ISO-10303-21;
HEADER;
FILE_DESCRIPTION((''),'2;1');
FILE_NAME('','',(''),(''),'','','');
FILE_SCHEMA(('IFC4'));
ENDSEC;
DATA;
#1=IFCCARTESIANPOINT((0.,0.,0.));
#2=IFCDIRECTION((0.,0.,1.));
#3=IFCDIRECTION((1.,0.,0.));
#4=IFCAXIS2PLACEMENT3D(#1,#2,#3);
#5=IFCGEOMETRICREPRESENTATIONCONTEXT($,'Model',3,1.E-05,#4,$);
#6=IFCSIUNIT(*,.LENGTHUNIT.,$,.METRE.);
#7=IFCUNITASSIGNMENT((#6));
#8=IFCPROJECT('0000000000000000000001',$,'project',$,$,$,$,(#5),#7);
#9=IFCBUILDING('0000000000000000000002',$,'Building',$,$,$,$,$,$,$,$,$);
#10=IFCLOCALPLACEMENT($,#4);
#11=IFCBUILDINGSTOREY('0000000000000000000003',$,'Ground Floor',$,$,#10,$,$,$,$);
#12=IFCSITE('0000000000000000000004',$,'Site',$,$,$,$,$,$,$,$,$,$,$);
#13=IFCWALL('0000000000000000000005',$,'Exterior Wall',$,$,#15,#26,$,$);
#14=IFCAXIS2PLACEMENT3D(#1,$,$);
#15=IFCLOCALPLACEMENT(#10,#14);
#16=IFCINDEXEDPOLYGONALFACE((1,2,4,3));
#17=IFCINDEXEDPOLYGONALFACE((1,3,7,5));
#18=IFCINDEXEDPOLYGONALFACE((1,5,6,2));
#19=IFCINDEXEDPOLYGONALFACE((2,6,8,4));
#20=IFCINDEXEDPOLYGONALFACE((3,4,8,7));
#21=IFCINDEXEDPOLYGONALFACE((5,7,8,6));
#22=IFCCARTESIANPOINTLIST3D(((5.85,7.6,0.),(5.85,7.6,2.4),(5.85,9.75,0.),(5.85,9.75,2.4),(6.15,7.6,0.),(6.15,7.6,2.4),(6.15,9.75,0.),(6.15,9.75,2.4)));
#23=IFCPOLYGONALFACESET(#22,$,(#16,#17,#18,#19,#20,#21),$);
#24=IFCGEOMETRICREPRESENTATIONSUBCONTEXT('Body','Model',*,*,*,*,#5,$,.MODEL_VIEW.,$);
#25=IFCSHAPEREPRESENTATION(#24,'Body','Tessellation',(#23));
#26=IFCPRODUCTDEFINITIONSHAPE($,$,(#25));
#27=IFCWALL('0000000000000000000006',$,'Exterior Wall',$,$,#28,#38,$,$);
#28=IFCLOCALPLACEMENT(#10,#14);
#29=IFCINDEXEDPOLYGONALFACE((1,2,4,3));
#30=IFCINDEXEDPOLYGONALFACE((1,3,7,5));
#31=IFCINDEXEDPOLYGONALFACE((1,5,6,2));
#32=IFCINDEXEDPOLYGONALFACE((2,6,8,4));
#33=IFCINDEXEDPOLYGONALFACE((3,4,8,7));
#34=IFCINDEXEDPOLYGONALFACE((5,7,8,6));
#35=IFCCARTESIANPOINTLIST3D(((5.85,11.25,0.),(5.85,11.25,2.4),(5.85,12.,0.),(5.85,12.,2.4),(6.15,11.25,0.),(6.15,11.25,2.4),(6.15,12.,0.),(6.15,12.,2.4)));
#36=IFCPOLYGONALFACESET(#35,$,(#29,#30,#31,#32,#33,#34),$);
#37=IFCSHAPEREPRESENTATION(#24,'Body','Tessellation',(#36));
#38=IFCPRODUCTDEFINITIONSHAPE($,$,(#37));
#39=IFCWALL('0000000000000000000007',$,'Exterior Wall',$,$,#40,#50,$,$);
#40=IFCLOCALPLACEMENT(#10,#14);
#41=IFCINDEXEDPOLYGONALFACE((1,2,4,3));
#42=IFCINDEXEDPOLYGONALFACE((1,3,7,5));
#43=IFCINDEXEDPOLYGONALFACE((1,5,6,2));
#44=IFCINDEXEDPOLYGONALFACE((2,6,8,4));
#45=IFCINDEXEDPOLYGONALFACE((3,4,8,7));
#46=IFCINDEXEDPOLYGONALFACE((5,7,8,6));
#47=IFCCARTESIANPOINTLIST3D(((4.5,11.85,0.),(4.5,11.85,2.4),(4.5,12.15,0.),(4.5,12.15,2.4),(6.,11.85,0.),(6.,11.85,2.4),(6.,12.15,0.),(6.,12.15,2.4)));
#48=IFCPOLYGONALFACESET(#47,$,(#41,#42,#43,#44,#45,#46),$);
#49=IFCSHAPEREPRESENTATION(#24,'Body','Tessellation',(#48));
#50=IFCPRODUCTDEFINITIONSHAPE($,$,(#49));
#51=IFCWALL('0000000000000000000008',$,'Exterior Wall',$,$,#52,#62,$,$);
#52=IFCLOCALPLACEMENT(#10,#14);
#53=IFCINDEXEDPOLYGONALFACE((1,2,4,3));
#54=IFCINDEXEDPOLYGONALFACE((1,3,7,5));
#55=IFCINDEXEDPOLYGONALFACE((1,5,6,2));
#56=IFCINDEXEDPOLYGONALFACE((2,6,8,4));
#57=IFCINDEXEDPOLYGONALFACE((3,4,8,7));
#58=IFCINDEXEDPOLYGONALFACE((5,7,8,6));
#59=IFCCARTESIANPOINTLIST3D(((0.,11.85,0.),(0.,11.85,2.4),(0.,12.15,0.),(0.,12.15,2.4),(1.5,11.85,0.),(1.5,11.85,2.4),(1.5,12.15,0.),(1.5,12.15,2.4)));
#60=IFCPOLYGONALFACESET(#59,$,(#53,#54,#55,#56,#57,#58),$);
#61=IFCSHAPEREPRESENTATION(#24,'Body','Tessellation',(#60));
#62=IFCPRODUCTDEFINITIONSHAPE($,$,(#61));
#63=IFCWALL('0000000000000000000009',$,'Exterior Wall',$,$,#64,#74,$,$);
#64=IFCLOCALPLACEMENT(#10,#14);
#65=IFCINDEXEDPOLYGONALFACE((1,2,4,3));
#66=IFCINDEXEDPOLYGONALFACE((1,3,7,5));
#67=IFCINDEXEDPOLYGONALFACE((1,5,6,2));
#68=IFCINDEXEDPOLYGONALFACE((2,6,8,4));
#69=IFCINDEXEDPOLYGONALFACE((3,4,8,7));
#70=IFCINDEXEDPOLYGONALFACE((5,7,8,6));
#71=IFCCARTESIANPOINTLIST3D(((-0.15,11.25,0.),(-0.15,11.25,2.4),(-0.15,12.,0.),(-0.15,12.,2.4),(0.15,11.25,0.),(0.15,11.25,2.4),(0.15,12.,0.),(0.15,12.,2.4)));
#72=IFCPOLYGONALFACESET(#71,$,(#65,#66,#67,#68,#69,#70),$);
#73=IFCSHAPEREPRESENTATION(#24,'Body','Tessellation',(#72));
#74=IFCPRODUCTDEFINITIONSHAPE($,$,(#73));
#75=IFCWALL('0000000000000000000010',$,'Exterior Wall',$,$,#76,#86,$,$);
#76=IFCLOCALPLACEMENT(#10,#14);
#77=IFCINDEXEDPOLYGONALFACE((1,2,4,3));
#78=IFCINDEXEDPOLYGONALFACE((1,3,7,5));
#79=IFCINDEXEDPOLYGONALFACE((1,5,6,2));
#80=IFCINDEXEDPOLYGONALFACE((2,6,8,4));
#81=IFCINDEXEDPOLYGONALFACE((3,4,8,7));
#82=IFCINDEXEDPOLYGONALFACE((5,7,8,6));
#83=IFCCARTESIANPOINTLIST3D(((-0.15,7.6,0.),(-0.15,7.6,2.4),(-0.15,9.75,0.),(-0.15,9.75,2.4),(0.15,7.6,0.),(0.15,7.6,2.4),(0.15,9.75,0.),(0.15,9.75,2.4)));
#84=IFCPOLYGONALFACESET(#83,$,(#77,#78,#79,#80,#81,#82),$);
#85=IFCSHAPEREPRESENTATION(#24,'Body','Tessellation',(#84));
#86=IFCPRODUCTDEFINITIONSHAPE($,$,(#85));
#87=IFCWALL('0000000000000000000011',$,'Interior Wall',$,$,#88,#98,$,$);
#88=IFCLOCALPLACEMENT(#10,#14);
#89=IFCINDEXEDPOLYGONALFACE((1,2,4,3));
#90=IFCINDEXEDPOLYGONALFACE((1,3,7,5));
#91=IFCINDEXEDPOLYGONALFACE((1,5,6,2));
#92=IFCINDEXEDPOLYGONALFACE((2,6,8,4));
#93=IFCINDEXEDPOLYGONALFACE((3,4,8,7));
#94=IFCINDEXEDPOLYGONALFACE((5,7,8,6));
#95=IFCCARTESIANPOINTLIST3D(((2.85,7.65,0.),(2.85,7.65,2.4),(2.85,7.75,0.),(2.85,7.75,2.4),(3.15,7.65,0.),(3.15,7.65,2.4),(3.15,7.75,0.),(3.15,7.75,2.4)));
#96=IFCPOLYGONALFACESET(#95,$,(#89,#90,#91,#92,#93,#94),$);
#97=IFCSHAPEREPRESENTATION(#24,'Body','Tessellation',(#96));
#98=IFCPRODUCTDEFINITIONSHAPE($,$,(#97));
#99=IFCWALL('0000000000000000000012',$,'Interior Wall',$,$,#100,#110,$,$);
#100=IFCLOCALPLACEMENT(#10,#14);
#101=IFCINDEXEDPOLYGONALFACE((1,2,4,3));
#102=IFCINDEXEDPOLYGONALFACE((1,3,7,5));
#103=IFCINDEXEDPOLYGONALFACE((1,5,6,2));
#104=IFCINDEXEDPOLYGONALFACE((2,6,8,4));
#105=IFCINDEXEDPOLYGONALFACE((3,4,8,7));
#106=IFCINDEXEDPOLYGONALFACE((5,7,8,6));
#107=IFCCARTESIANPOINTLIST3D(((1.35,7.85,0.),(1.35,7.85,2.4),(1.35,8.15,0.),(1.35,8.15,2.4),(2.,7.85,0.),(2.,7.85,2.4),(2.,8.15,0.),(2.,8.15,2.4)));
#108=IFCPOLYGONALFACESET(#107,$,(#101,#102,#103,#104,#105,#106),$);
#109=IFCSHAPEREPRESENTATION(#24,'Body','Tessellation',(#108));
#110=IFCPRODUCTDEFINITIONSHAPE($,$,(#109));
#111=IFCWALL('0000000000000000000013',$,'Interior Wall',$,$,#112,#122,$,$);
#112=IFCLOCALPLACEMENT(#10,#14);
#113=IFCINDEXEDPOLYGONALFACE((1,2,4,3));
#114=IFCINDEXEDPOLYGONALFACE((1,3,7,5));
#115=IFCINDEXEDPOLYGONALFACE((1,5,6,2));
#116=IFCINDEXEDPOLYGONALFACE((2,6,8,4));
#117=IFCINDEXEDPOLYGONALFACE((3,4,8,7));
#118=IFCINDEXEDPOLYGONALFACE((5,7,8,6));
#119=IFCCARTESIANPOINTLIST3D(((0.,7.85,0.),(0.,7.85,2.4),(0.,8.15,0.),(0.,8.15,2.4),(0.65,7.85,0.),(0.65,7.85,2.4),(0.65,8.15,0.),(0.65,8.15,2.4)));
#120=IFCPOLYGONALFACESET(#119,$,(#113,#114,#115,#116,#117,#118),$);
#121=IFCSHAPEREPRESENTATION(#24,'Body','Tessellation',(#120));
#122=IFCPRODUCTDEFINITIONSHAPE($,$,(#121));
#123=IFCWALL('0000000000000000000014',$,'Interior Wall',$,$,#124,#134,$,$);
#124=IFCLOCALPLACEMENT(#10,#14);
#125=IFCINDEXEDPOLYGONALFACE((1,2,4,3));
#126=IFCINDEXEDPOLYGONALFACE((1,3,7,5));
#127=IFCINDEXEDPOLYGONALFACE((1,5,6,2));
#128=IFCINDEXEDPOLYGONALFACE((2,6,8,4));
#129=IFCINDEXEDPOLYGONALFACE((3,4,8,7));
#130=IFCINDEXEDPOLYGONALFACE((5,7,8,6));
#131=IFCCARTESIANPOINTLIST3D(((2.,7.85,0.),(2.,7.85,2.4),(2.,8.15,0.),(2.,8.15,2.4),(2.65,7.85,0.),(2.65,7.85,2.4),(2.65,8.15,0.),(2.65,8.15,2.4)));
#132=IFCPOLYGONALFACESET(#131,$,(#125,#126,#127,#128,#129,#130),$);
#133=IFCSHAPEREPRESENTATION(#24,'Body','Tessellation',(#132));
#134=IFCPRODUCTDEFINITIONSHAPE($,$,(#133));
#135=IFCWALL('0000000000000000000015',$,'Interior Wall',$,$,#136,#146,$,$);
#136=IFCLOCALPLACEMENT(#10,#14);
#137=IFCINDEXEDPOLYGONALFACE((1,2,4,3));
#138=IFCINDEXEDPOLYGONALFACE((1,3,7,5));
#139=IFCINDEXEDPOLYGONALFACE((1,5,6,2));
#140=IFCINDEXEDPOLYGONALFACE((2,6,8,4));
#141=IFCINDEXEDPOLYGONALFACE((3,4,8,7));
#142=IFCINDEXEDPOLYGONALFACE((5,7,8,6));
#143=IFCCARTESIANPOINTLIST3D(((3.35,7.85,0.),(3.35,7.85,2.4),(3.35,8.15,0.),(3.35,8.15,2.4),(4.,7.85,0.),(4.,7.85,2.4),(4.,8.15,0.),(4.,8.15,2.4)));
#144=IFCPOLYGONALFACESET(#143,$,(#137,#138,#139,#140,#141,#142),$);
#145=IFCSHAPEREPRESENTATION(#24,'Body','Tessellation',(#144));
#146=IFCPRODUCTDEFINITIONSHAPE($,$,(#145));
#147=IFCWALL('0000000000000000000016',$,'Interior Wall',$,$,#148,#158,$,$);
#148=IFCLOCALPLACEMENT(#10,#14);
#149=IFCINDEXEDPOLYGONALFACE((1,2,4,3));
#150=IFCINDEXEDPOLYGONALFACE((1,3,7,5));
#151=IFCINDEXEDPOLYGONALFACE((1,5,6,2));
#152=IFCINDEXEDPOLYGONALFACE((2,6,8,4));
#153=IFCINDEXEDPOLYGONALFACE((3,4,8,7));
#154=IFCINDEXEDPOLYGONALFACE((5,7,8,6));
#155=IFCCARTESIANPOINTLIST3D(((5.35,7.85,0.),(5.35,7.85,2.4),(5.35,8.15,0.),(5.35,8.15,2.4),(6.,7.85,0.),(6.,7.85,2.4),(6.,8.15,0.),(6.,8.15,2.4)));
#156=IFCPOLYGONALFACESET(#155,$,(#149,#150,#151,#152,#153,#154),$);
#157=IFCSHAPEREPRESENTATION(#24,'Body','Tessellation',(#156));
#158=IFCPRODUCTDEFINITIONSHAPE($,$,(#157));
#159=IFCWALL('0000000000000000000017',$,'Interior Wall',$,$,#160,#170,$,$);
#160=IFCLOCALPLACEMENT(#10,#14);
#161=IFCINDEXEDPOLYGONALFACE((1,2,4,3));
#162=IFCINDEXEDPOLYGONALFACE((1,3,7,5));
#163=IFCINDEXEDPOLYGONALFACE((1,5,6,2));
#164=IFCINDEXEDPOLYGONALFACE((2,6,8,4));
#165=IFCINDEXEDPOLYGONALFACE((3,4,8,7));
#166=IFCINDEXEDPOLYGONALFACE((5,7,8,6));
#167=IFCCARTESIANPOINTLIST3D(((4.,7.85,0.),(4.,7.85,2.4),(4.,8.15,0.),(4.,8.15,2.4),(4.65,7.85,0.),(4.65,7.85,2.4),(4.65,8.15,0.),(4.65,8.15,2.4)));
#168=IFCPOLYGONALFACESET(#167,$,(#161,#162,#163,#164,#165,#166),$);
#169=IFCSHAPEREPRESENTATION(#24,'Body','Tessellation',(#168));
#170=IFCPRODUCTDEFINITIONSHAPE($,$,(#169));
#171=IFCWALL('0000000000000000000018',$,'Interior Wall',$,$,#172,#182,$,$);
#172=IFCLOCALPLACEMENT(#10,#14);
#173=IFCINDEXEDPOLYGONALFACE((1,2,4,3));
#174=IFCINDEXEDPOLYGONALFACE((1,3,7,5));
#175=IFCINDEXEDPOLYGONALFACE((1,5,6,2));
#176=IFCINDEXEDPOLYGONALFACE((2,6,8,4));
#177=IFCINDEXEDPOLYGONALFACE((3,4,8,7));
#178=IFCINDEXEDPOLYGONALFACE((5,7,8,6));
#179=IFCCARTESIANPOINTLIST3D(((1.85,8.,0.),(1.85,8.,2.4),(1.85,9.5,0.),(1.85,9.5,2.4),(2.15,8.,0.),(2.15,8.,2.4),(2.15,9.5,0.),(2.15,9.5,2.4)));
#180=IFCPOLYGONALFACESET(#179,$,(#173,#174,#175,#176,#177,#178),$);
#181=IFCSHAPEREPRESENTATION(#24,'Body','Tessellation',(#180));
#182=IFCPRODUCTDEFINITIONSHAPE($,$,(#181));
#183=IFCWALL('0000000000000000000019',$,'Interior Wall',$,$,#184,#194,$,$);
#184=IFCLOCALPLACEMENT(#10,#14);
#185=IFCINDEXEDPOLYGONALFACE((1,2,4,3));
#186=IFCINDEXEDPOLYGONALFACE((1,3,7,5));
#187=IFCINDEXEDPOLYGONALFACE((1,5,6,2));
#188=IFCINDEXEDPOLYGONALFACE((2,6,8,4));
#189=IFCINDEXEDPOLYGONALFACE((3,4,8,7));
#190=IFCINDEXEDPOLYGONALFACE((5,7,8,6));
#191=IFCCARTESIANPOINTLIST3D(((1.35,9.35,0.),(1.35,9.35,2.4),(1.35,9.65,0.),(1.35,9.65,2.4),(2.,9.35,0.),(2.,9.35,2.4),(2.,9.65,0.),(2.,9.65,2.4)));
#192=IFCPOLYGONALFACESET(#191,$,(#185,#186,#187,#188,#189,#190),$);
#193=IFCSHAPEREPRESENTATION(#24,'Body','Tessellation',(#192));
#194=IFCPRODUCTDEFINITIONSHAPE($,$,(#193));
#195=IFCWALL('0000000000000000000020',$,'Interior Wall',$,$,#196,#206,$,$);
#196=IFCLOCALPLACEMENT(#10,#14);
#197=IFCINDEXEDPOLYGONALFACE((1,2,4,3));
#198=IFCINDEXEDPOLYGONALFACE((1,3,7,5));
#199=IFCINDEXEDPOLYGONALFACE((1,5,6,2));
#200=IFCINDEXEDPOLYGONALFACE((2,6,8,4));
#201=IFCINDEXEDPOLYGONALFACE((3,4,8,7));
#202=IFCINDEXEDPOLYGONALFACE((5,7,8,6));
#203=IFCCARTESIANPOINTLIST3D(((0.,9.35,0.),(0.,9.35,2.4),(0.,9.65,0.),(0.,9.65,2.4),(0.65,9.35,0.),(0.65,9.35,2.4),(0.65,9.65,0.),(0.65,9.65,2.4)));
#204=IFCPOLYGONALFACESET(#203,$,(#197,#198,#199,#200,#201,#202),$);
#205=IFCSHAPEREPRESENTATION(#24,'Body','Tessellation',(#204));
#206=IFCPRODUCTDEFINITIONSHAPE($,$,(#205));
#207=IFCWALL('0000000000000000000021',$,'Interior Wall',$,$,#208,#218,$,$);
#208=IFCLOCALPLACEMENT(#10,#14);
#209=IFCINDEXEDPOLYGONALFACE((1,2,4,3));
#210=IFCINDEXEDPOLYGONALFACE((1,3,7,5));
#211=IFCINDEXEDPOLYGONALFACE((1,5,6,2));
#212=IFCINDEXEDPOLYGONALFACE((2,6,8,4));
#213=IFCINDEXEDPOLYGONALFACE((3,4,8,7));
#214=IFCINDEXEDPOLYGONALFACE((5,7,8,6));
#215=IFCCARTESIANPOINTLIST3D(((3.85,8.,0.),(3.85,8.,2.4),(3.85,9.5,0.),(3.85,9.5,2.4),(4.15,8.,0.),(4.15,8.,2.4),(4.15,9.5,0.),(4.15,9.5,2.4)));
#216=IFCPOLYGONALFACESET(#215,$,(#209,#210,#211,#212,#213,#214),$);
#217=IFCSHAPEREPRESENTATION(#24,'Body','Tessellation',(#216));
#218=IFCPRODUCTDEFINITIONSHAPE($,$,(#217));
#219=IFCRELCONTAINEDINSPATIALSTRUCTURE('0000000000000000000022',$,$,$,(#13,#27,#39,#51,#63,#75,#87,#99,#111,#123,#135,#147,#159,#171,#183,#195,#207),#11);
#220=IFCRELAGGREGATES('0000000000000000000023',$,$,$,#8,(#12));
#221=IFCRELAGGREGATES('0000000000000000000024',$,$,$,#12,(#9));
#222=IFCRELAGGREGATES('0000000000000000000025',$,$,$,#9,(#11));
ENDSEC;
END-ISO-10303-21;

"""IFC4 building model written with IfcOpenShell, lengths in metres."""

from ifc_helpers import new_model, si_unit, frame, origin_with_axes, place, context, subcontext, project, spatial, indexed_curve, outline, extrude, element, save


model = new_model("IFC4")

# Units and contexts
model_context = context("Model", 3, precision=1e-05, world=origin_with_axes())
body_context = subcontext(model_context, "Body", "Model", "MODEL_VIEW")
ifc_project = project(units=[si_unit("LENGTHUNIT", "METRE")], contexts=[model_context])

# Site, building, storey
site = spatial("IfcSite", under=ifc_project, Name="Site")
building = spatial("IfcBuilding", under=site, Name="Building")
storey_placement = place(None, origin_with_axes())
storey = spatial("IfcBuildingStorey", under=building, at=storey_placement, Name="Ground Floor")

# Walls
wall_1_placement = place(storey_placement, frame((6.0, 7.6, 0.0), z_axis=(0.0, 0.0, 1.0), x_axis=(0.0, 1.0, 0.0)))
element("IfcWall", 1, at=wall_1_placement, inside=storey, Name="Exterior Wall", context=body_context, shape_type="SweptSolid", body=[
    extrude(outline(indexed_curve([(0.0, 0.0), (0.0, 0.3), (2.15, 0.3), (2.15, 0.0), (0.0, 0.0)], self_intersect=False)), frame((0.0, -0.15, 0.0), z_axis=(0.0, 0.0, 1.0), x_axis=(1.0, 0.0, 0.0)), (0.0, 0.0, 1.0), 2.4),
])
wall_2_placement = place(storey_placement, frame((6.0, 11.25, 0.0), z_axis=(0.0, 0.0, 1.0), x_axis=(0.0, 1.0, 0.0)))
element("IfcWall", 2, at=wall_2_placement, inside=storey, Name="Exterior Wall", context=body_context, shape_type="SweptSolid", body=[
    extrude(outline(indexed_curve([(0.0, 0.0), (0.0, 0.3), (0.75, 0.3), (0.75, 0.0), (0.0, 0.0)], self_intersect=False)), frame((0.0, -0.15, 0.0), z_axis=(0.0, 0.0, 1.0), x_axis=(1.0, 0.0, 0.0)), (0.0, 0.0, 1.0), 2.4),
])
for number, where, z_axis, x_axis, name in (
    (3, (6.0, 12.0, 0.0), (0.0, 0.0, 1.0), (-1.0, 0.0, 0.0), "Exterior Wall"),
    (4, (1.5, 12.0, 0.0), (0.0, 0.0, 1.0), (-1.0, 0.0, 0.0), "Exterior Wall"),
):
    element("IfcWall", number, at=place(storey_placement, frame(where, z_axis=z_axis, x_axis=x_axis)), inside=storey, Name=name, context=body_context, shape_type="SweptSolid", body=[
        extrude(outline(indexed_curve([(0.0, 0.0), (0.0, 0.3), (1.5, 0.3), (1.5, 0.0), (0.0, 0.0)], self_intersect=False)), frame((0.0, -0.15, 0.0), z_axis=(0.0, 0.0, 1.0), x_axis=(1.0, 0.0, 0.0)), (0.0, 0.0, 1.0), 2.4),
    ])
wall_3_placement = place(storey_placement, frame((0.0, 12.0, 0.0), z_axis=(0.0, 0.0, 1.0), x_axis=(0.0, -1.0, 0.0)))
element("IfcWall", 5, at=wall_3_placement, inside=storey, Name="Exterior Wall", context=body_context, shape_type="SweptSolid", body=[
    extrude(outline(indexed_curve([(0.0, 0.0), (0.0, 0.3), (0.75, 0.3), (0.75, 0.0), (0.0, 0.0)], self_intersect=False)), frame((0.0, -0.15, 0.0), z_axis=(0.0, 0.0, 1.0), x_axis=(1.0, 0.0, 0.0)), (0.0, 0.0, 1.0), 2.4),
])
wall_4_placement = place(storey_placement, frame((0.0, 9.75, 0.0), z_axis=(0.0, 0.0, 1.0), x_axis=(0.0, -1.0, 0.0)))
element("IfcWall", 6, at=wall_4_placement, inside=storey, Name="Exterior Wall", context=body_context, shape_type="SweptSolid", body=[
    extrude(outline(indexed_curve([(0.0, 0.0), (0.0, 0.3), (2.15, 0.3), (2.15, 0.0), (0.0, 0.0)], self_intersect=False)), frame((0.0, -0.15, 0.0), z_axis=(0.0, 0.0, 1.0), x_axis=(1.0, 0.0, 0.0)), (0.0, 0.0, 1.0), 2.4),
])
wall_5_placement = place(storey_placement, frame((3.0, 7.75, 0.0), z_axis=(0.0, 0.0, 1.0), x_axis=(0.0, -1.0, 0.0)))
element("IfcWall", 7, at=wall_5_placement, inside=storey, Name="Interior Wall", context=body_context, shape_type="SweptSolid", body=[
    extrude(outline(indexed_curve([(0.0, 0.0), (0.0, 0.3), (0.1, 0.3), (0.1, 0.0), (0.0, 0.0)], self_intersect=False)), frame((0.0, -0.15, 0.0), z_axis=(0.0, 0.0, 1.0), x_axis=(1.0, 0.0, 0.0)), (0.0, 0.0, 1.0), 2.4),
])
for number, where, z_axis, x_axis, name in (
    (8, (2.0, 8.0, 0.0), (0.0, 0.0, 1.0), (-1.0, 0.0, 0.0), "Interior Wall"),
    (9, (0.65, 8.0, 0.0), (0.0, 0.0, 1.0), (-1.0, 0.0, 0.0), "Interior Wall"),
    (10, (2.65, 8.0, 0.0), (0.0, 0.0, 1.0), (-1.0, 0.0, 0.0), "Interior Wall"),
    (11, (4.0, 8.0, 0.0), (0.0, 0.0, 1.0), (-1.0, 0.0, 0.0), "Interior Wall"),
):
    element("IfcWall", number, at=place(storey_placement, frame(where, z_axis=z_axis, x_axis=x_axis)), inside=storey, Name=name, context=body_context, shape_type="SweptSolid", body=[
        extrude(outline(indexed_curve([(0.0, 0.0), (0.0, 0.3), (0.65, 0.3), (0.65, 0.0), (0.0, 0.0)], self_intersect=False)), frame((0.0, -0.15, 0.0), z_axis=(0.0, 0.0, 1.0), x_axis=(1.0, 0.0, 0.0)), (0.0, 0.0, 1.0), 2.4),
    ])
for number, where, z_axis, x_axis, name in (
    (12, (6.0, 8.0, 0.0), (0.0, 0.0, 1.0), (-1.0, 0.0, 0.0), "Interior Wall"),
    (13, (4.65, 8.0, 0.0), (0.0, 0.0, 1.0), (-1.0, 0.0, 0.0), "Interior Wall"),
):
    element("IfcWall", number, at=place(storey_placement, frame(where, z_axis=z_axis, x_axis=x_axis)), inside=storey, Name=name, context=body_context, shape_type="SweptSolid", body=[
        extrude(outline(indexed_curve([(0.0, 0.0), (0.0, 0.3), (0.65, 0.3), (0.65, 0.0), (0.0, 0.0)], self_intersect=False)), frame((0.0, -0.15, 0.0), z_axis=(0.0, 0.0, 1.0), x_axis=(1.0, 0.0, 0.0)), (0.0, 0.0, 1.0), 2.4),
    ])
wall_6_placement = place(storey_placement, frame((2.0, 8.0, 0.0), z_axis=(0.0, 0.0, 1.0), x_axis=(0.0, 1.0, 0.0)))
element("IfcWall", 14, at=wall_6_placement, inside=storey, Name="Interior Wall", context=body_context, shape_type="SweptSolid", body=[
    extrude(outline(indexed_curve([(0.0, 0.0), (0.0, 0.3), (1.5, 0.3), (1.5, 0.0), (0.0, 0.0)], self_intersect=False)), frame((0.0, -0.15, 0.0), z_axis=(0.0, 0.0, 1.0), x_axis=(1.0, 0.0, 0.0)), (0.0, 0.0, 1.0), 2.4),
])
for number, where, z_axis, x_axis, name in (
    (15, (2.0, 9.5, 0.0), (0.0, 0.0, 1.0), (-1.0, 0.0, 0.0), "Interior Wall"),
    (16, (0.65, 9.5, 0.0), (0.0, 0.0, 1.0), (-1.0, 0.0, 0.0), "Interior Wall"),
):
    element("IfcWall", number, at=place(storey_placement, frame(where, z_axis=z_axis, x_axis=x_axis)), inside=storey, Name=name, context=body_context, shape_type="SweptSolid", body=[
        extrude(outline(indexed_curve([(0.0, 0.0), (0.0, 0.3), (0.65, 0.3), (0.65, 0.0), (0.0, 0.0)], self_intersect=False)), frame((0.0, -0.15, 0.0), z_axis=(0.0, 0.0, 1.0), x_axis=(1.0, 0.0, 0.0)), (0.0, 0.0, 1.0), 2.4),
    ])
wall_7_placement = place(storey_placement, frame((4.0, 8.0, 0.0), z_axis=(0.0, 0.0, 1.0), x_axis=(0.0, 1.0, 0.0)))
element("IfcWall", 17, at=wall_7_placement, inside=storey, Name="Interior Wall", context=body_context, shape_type="SweptSolid", body=[
    extrude(outline(indexed_curve([(0.0, 0.0), (0.0, 0.3), (1.5, 0.3), (1.5, 0.0), (0.0, 0.0)], self_intersect=False)), frame((0.0, -0.15, 0.0), z_axis=(0.0, 0.0, 1.0), x_axis=(1.0, 0.0, 0.0)), (0.0, 0.0, 1.0), 2.4),
])

save(model, "model.ifc")
